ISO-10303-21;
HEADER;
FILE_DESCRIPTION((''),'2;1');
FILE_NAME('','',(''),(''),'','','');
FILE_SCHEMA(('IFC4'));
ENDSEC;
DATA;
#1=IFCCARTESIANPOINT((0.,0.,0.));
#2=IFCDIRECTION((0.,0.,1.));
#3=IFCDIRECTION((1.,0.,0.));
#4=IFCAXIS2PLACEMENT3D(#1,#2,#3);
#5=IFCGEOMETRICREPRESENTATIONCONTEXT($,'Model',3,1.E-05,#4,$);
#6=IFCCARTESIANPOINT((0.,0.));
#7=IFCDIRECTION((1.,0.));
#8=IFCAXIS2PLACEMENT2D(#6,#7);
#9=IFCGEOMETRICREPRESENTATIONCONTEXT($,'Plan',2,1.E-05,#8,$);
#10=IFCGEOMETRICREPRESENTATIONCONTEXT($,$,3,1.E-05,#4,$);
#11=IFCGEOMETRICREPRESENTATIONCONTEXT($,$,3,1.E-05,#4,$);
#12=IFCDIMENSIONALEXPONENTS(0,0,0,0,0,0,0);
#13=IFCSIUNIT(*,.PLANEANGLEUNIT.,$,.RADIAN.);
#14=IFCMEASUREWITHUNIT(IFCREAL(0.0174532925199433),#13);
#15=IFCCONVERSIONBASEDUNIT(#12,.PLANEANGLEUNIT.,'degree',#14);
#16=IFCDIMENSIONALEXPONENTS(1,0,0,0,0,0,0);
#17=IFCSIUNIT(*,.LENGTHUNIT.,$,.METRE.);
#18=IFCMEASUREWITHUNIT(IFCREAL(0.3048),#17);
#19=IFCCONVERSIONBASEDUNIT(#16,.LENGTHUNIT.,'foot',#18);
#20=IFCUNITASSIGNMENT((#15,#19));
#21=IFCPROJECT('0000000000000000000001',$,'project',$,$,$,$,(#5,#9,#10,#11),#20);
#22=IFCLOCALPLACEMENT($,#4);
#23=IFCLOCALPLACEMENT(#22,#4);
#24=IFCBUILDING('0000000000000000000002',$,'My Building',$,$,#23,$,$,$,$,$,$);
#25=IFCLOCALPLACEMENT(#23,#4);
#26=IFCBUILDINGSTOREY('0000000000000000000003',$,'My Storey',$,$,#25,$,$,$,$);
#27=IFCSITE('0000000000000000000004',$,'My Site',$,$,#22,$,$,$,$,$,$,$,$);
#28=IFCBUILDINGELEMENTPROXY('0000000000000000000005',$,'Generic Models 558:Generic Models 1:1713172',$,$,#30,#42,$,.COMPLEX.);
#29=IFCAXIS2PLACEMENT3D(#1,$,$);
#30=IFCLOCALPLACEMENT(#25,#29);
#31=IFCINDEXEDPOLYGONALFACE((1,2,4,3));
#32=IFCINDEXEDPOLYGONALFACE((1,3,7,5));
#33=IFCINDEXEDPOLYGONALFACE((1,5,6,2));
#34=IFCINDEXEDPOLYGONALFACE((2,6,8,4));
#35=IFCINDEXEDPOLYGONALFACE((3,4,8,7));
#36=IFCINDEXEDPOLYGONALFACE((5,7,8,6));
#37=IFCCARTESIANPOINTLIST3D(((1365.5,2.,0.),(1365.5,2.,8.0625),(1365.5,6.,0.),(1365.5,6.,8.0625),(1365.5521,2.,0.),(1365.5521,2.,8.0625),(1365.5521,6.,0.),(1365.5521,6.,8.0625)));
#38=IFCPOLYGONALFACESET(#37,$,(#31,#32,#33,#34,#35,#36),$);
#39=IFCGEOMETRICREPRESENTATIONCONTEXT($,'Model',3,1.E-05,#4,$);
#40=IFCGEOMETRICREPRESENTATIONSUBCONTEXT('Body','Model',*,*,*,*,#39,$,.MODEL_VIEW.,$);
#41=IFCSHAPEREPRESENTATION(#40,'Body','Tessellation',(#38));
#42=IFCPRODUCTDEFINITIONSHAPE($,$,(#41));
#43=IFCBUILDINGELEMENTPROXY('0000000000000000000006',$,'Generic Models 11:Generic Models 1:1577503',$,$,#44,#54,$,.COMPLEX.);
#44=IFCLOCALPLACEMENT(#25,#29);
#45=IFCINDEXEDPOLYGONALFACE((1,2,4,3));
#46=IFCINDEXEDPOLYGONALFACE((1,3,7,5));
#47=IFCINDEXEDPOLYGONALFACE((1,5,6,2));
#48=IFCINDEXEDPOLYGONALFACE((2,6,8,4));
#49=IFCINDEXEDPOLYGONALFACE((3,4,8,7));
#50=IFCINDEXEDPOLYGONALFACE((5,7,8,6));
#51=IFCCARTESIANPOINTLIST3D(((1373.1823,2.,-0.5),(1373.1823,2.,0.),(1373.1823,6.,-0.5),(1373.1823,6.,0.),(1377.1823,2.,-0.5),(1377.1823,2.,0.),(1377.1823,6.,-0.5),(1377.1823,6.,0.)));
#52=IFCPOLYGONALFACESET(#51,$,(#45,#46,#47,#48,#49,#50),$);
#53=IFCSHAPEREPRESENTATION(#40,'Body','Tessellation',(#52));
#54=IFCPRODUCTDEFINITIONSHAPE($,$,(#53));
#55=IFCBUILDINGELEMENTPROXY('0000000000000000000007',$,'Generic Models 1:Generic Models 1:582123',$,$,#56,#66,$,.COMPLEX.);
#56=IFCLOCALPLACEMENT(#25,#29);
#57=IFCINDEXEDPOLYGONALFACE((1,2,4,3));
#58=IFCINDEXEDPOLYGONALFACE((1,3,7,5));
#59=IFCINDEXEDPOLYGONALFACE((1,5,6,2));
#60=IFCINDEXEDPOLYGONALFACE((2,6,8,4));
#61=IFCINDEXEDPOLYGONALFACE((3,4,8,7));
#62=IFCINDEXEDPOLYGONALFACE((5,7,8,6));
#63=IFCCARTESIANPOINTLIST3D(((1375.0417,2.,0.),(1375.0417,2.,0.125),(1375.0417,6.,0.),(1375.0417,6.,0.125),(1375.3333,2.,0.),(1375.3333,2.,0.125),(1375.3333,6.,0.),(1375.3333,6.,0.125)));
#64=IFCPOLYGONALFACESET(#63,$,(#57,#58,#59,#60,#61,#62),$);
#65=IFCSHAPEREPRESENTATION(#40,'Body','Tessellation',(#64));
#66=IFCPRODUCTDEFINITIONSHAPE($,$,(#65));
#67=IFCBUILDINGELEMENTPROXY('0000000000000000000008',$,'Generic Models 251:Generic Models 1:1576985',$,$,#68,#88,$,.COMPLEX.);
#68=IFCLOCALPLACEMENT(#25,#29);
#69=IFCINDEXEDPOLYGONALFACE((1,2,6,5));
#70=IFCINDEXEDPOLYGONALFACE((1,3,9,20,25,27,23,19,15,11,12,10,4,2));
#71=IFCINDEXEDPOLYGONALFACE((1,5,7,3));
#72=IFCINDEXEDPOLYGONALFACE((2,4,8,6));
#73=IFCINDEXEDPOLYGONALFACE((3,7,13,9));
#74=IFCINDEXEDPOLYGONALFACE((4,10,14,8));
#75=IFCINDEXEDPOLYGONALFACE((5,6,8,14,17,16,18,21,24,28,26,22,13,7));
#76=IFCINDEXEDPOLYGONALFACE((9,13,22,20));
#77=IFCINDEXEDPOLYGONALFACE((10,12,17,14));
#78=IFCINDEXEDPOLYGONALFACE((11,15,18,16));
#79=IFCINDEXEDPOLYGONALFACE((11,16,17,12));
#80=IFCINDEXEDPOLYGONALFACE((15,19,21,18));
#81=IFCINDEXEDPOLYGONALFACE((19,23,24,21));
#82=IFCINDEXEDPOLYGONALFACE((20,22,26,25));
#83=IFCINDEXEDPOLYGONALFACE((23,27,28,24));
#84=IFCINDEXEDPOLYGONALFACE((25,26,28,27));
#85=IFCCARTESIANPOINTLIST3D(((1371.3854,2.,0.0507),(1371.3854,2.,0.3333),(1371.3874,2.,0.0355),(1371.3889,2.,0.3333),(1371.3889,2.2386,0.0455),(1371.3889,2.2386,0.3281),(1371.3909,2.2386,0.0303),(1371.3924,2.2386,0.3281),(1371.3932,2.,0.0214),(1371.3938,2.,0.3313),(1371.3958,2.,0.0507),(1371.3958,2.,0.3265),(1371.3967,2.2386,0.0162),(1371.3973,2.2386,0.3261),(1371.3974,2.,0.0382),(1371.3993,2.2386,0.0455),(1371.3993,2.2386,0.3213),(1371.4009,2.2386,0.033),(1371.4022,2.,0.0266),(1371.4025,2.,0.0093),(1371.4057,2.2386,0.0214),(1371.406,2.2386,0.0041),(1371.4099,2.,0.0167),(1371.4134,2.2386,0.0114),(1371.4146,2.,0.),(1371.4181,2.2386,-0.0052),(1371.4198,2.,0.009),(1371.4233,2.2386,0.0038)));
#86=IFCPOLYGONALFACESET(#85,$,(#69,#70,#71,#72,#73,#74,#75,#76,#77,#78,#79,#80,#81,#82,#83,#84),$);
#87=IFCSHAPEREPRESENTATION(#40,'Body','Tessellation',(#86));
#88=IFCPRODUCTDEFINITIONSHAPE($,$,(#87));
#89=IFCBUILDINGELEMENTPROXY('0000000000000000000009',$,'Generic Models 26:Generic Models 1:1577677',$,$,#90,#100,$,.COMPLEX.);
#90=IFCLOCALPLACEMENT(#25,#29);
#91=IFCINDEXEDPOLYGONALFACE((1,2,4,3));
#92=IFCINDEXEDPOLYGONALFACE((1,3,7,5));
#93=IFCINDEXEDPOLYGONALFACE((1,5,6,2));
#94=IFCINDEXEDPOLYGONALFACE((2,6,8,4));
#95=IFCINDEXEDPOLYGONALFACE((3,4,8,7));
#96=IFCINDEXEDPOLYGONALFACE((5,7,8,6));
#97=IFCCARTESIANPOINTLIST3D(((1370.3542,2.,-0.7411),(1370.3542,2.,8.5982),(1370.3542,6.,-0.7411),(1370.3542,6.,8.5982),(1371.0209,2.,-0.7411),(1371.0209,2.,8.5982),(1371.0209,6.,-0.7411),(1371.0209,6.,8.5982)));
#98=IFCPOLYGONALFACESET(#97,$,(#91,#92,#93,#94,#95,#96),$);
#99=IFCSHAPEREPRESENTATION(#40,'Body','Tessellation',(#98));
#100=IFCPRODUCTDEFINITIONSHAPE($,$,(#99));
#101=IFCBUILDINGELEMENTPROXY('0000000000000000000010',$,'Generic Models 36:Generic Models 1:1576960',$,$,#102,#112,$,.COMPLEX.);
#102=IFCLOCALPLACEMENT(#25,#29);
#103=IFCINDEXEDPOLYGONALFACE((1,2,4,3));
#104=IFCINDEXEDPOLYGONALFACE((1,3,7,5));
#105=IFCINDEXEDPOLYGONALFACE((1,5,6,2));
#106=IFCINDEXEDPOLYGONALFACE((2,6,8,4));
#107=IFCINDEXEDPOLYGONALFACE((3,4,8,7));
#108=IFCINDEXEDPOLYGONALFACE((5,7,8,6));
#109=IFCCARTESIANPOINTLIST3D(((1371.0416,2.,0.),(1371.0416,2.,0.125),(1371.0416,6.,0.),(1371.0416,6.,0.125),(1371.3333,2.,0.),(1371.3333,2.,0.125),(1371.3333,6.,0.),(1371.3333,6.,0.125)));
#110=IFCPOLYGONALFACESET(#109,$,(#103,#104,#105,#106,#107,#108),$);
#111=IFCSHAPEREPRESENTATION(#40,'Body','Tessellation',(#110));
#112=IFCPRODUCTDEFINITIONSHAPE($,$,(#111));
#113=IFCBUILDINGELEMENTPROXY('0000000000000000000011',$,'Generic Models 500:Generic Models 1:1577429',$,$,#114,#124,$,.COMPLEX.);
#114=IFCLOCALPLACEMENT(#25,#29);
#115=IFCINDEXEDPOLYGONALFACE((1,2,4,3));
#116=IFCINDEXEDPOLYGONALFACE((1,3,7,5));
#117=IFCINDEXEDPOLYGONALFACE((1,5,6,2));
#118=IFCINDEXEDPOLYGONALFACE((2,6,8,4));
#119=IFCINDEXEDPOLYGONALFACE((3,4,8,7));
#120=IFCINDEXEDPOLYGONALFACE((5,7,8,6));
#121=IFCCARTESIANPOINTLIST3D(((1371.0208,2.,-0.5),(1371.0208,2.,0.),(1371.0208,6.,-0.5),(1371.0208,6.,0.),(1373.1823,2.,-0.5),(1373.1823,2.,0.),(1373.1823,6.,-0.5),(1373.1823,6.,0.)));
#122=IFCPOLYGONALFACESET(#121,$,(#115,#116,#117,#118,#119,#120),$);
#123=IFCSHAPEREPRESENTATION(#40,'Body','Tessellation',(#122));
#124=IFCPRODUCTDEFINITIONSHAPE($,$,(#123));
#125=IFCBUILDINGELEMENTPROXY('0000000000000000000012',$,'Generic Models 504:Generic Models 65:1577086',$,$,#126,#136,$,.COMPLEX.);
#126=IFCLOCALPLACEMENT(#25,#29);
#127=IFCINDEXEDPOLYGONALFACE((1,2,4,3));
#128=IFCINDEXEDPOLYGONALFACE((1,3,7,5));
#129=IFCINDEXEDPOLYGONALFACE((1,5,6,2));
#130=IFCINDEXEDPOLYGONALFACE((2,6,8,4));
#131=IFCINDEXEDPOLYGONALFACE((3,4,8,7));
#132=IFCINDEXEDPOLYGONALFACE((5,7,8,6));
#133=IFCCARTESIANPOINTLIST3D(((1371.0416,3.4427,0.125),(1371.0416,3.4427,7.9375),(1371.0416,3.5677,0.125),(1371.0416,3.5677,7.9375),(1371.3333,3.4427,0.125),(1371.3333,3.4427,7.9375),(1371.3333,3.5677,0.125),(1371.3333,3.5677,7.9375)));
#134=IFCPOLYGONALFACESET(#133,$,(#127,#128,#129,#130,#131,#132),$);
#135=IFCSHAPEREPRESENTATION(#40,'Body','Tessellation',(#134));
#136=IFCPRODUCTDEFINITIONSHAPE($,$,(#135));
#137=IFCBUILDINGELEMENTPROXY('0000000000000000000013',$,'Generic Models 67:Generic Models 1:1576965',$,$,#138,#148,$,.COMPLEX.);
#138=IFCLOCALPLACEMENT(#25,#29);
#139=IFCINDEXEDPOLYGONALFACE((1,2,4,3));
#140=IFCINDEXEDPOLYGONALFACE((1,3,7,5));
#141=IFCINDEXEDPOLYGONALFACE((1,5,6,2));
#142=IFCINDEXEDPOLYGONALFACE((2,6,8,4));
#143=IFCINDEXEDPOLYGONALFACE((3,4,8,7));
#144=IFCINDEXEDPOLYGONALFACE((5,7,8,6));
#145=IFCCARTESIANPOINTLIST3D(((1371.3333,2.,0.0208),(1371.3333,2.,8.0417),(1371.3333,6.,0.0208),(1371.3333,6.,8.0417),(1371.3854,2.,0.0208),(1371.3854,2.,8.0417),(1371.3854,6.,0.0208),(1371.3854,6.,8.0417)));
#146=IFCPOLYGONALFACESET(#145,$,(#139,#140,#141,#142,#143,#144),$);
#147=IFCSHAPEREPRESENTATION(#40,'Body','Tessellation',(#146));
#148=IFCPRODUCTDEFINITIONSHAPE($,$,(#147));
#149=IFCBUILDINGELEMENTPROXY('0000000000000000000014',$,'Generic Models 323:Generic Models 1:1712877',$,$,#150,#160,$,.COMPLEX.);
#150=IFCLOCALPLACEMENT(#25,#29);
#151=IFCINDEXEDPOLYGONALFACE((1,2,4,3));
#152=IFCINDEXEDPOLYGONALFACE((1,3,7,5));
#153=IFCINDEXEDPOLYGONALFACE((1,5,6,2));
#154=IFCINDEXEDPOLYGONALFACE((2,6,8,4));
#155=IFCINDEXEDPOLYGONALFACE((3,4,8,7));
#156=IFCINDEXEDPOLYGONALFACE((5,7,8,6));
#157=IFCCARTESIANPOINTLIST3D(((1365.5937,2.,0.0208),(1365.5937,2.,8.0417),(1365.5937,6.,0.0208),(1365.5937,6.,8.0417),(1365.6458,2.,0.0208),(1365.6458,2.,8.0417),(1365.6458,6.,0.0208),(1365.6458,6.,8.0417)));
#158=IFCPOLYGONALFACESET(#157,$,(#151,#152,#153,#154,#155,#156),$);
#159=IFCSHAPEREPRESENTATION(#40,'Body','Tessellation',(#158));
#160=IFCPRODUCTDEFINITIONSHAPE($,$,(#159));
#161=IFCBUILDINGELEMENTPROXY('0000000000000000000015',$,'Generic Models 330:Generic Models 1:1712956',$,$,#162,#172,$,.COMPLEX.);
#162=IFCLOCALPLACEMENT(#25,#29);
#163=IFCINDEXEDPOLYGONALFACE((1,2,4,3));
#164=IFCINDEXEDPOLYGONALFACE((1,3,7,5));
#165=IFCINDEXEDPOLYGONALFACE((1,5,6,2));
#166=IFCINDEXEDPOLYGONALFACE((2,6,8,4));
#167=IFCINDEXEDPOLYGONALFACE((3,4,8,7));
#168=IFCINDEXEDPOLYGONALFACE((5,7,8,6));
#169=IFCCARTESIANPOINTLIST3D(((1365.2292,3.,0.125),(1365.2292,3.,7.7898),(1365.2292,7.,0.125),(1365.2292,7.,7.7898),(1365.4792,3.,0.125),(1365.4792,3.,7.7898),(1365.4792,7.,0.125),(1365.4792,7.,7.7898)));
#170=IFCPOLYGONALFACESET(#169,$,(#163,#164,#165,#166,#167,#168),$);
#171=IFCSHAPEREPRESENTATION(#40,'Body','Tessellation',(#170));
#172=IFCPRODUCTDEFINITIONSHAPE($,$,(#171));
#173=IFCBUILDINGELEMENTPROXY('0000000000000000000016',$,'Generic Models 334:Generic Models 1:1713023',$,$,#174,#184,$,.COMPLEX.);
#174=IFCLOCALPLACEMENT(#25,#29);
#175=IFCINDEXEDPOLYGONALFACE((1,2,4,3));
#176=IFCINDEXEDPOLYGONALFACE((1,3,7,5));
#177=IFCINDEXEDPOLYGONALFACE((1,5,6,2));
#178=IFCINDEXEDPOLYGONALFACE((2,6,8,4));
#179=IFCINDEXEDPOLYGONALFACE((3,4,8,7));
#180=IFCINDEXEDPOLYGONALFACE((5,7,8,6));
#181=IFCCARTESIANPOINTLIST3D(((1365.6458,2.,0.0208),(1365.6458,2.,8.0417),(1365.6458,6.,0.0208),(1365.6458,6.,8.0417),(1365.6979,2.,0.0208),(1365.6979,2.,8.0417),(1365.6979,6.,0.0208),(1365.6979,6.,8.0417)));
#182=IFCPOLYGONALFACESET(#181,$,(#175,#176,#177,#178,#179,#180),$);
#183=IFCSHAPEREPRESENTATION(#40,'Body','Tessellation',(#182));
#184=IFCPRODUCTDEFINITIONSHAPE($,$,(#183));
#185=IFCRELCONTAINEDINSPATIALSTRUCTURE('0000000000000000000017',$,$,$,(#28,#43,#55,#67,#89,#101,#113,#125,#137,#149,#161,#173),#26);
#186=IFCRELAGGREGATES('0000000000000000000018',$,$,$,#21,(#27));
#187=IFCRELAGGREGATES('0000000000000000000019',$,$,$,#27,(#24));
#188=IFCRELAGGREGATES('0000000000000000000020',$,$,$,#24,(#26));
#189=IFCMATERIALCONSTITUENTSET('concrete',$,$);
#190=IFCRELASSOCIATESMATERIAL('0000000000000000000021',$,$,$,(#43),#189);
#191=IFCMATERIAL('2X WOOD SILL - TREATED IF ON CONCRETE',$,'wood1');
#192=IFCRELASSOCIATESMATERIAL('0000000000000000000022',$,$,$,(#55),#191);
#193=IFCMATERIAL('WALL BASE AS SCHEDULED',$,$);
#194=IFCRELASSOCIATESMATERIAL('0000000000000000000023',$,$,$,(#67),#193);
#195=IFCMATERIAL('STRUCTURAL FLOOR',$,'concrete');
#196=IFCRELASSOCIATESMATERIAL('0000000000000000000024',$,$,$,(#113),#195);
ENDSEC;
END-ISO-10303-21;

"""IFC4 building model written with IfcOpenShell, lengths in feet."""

from ifc_helpers import new_model, entity, si_unit, converted_unit, frame, origin_with_axes, origin_2d_with_axis, place, context, subcontext, project, spatial, polyline, outline, extrude, material, constituent_set, element, save


model = new_model("IFC4")

# Units and contexts
model_context_1 = context("Model", 3, precision=1e-05, world=origin_with_axes())
plan_context = context("Plan", 2, precision=1e-05, world=origin_2d_with_axis())
model_context_2 = context("Model", 3, precision=1e-05, world=origin_with_axes())
context_of_model_1 = context(None, 3, precision=1e-05, world=origin_with_axes())
context_of_model_2 = context(None, 3, precision=1e-05, world=origin_with_axes())
body_context = subcontext(model_context_2, "Body", "Model", "MODEL_VIEW")
ifc_project = project(units=[converted_unit("PLANEANGLEUNIT", "degree", entity("IfcReal", 0.0174532925199433), si_unit("PLANEANGLEUNIT", "RADIAN"), dimensions=[0, 0, 0, 0, 0, 0, 0]), converted_unit("LENGTHUNIT", "foot", entity("IfcReal", 0.3048), si_unit("LENGTHUNIT", "METRE"), dimensions=[1, 0, 0, 0, 0, 0, 0])], contexts=[model_context_1, plan_context, context_of_model_1, context_of_model_2])

# Site, building, storey
site_placement = place(None, origin_with_axes())
site = spatial("IfcSite", under=ifc_project, at=site_placement, Name="My Site")
building_placement = place(site_placement, origin_with_axes())
building = spatial("IfcBuilding", under=site, at=building_placement, Name="My Building")
storey_placement = place(building_placement, origin_with_axes())
storey = spatial("IfcBuildingStorey", under=building, at=storey_placement, Name="My Storey")

# Building element proxies
proxy_1_placement = place(storey_placement, frame((1365.5, 6.0, 0.0), z_axis=(0.0, -1.0, 0.0), x_axis=(0.0, 0.0, 1.0)))
element("IfcBuildingElementProxy", 1, at=proxy_1_placement, inside=storey, Name="Generic Models 558:Generic Models 1:1713172", PredefinedType="COMPLEX", context=body_context, shape_type="SweptSolid", body=[
    extrude(outline(polyline([(-4.0312, -0.026), (4.0312, -0.026), (4.0312, 0.026), (-4.0312, 0.026), (-4.0312, -0.026)])), frame((4.0312, -0.026, 0.0), z_axis=(0.0, 0.0, -1.0), x_axis=(1.0, 0.0, 0.0)), (0.0, 0.0, -1.0), 4.0),
])
ifc_constituent_set = constituent_set(Name="concrete")
proxy_2_placement = place(storey_placement, frame((1373.1823, 6.0, -0.5), z_axis=(0.0, -1.0, 0.0), x_axis=(0.0, 0.0, -1.0)))
element("IfcBuildingElementProxy", 2, at=proxy_2_placement, inside=storey, material=ifc_constituent_set, Name="Generic Models 11:Generic Models 1:1577503", PredefinedType="COMPLEX", context=body_context, shape_type="SweptSolid", body=[
    extrude(outline(polyline([(-0.25, -2.0), (0.25, -2.0), (0.25, 2.0), (-0.25, 2.0), (-0.25, -2.0)])), frame((-0.25, 2.0, 0.0), z_axis=(0.0, 0.0, -1.0), x_axis=(-1.0, 0.0, 0.0)), (0.0, 0.0, -1.0), 4.0),
])
ifc_material_1 = material(Name="2X WOOD SILL - TREATED IF ON CONCRETE", Category="wood1")
proxy_3_placement = place(storey_placement, frame((1375.0417, 6.0, 0.0), z_axis=(0.0, -1.0, 0.0), x_axis=(0.0, 0.0, -1.0)))
element("IfcBuildingElementProxy", 3, at=proxy_3_placement, inside=storey, material=ifc_material_1, Name="Generic Models 1:Generic Models 1:582123", PredefinedType="COMPLEX", context=body_context, shape_type="SweptSolid", body=[
    extrude(outline(polyline([(-0.0625, -0.1458), (0.0625, -0.1458), (0.0625, 0.1458), (-0.0625, 0.1458), (-0.0625, -0.1458)])), frame((-0.0625, 0.1458, 0.0), z_axis=(0.0, 0.0, -1.0), x_axis=(1.0, 0.0, 0.0)), (0.0, 0.0, -1.0), 4.0),
])
ifc_material_2 = material(Name="WALL BASE AS SCHEDULED")
proxy_4_placement = place(storey_placement, frame((1371.3854, 6.0, 0.0), z_axis=(0.0, -1.0, 0.0), x_axis=(0.0, 0.0, -1.0)))
element("IfcBuildingElementProxy", 4, at=proxy_4_placement, inside=storey, material=ifc_material_2, Name="Generic Models 251:Generic Models 1:1576985", PredefinedType="COMPLEX", context=body_context, shape_type="SweptSolid", body=[
    extrude(outline(polyline([(0.0971, 0.0), (0.1059, -0.009), (0.1142, -0.0027), (0.1035, 0.0082), (0.0904, 0.016), (0.0756, 0.02), (0.0603, 0.0202), (-0.2202, -0.0144), (-0.2197, -0.0179), (-0.2172, -0.0225), (-0.2121, -0.0239), (0.0616, 0.0098), (0.0742, 0.0097), (0.0863, 0.0064), (0.0971, 0.0)])), frame((-0.1078, 0.0161, 3.7614), z_axis=(-0.000001, 0.0, -1.0), x_axis=(0.992503, 0.122219, -0.000004)), (-0.023549, 0.011857, -0.999652), 0.2387),
])
proxy_5_placement = place(storey_placement, frame((1370.3542, 6.0, -0.7411), z_axis=(0.0, -1.0, 0.0), x_axis=(0.0, 0.0, -1.0)))
element("IfcBuildingElementProxy", 5, at=proxy_5_placement, inside=storey, Name="Generic Models 26:Generic Models 1:1577677", PredefinedType="COMPLEX", context=body_context, shape_type="SweptSolid", body=[
    extrude(outline(polyline([(-0.3333, -4.6697), (0.3333, -4.6697), (0.3333, 4.6697), (-0.3333, 4.6697), (-0.3333, -4.6697)])), frame((-4.6697, 0.3333, 0.0), z_axis=(0.0, 0.0, -1.0), x_axis=(0.0, -1.0, 0.0)), (0.0, 0.0, -1.0), 4.0),
])
proxy_6_placement = place(storey_placement, frame((1371.0416, 6.0, 0.0), z_axis=(0.0, -1.0, 0.0), x_axis=(0.0, 0.0, -1.0)))
element("IfcBuildingElementProxy", 6, at=proxy_6_placement, inside=storey, Name="Generic Models 36:Generic Models 1:1576960", PredefinedType="COMPLEX", context=body_context, shape_type="SweptSolid", body=[
    extrude(outline(polyline([(-0.0625, -0.1458), (0.0625, -0.1458), (0.0625, 0.1458), (-0.0625, 0.1458), (-0.0625, -0.1458)])), frame((-0.0625, 0.1458, 0.0), z_axis=(0.0, 0.0, -1.0), x_axis=(1.0, 0.0, 0.0)), (0.0, 0.0, -1.0), 4.0),
])
ifc_material_3 = material(Name="STRUCTURAL FLOOR", Category="concrete")
proxy_7_placement = place(storey_placement, frame((1371.0208, 6.0, -0.5), z_axis=(0.0, -1.0, 0.0), x_axis=(0.0, 0.0, -1.0)))
element("IfcBuildingElementProxy", 7, at=proxy_7_placement, inside=storey, material=ifc_material_3, Name="Generic Models 500:Generic Models 1:1577429", PredefinedType="COMPLEX", context=body_context, shape_type="SweptSolid", body=[
    extrude(outline(polyline([(-0.25, -1.0807), (0.25, -1.0807), (0.25, 1.0807), (-0.25, 1.0807), (-0.25, -1.0807)])), frame((-0.25, 1.0807, 0.0), z_axis=(0.0, 0.0, -1.0), x_axis=(1.0, 0.0, 0.0)), (0.0, 0.0, -1.0), 4.0),
])
proxy_8_placement = place(storey_placement, frame((1371.0416, 3.4427, 0.125), z_axis=(1.0, 0.0, 0.0), x_axis=(0.0, 0.0, -1.0)))
element("IfcBuildingElementProxy", 8, at=proxy_8_placement, inside=storey, Name="Generic Models 504:Generic Models 65:1577086", PredefinedType="COMPLEX", context=body_context, shape_type="SweptSolid", body=[
    extrude(outline(polyline([(-3.9062, -0.0625), (3.9062, -0.0625), (3.9062, 0.0625), (-3.9062, 0.0625), (-3.9062, -0.0625)])), frame((-3.9062, 0.0625, 0.0), z_axis=(0.0, 0.0, -1.0), x_axis=(1.0, 0.0, 0.0)), (0.0, 0.0, -1.0), 0.2917),
])
proxy_9_placement = place(storey_placement, frame((1371.3333, 6.0, 0.0208), z_axis=(0.0, -1.0, 0.0), x_axis=(0.0, 0.0, -1.0)))
element("IfcBuildingElementProxy", 9, at=proxy_9_placement, inside=storey, Name="Generic Models 67:Generic Models 1:1576965", PredefinedType="COMPLEX", context=body_context, shape_type="SweptSolid", body=[
    extrude(outline(polyline([(-0.026, -4.0104), (0.026, -4.0104), (0.026, 4.0104), (-0.026, 4.0104), (-0.026, -4.0104)])), frame((-4.0104, 0.026, 0.0), z_axis=(0.0, 0.0, -1.0), x_axis=(0.0, 1.0, 0.0)), (0.0, 0.0, -1.0), 4.0),
])
proxy_10_placement = place(storey_placement, frame((1365.5937, 6.0, 0.0208), z_axis=(0.0, -1.0, 0.0), x_axis=(0.0, 0.0, 1.0)))
element("IfcBuildingElementProxy", 10, at=proxy_10_placement, inside=storey, Name="Generic Models 323:Generic Models 1:1712877", PredefinedType="COMPLEX", context=body_context, shape_type="SweptSolid", body=[
    extrude(outline(polyline([(-4.0104, -0.026), (4.0104, -0.026), (4.0104, 0.026), (-4.0104, 0.026), (-4.0104, -0.026)])), frame((4.0104, -0.026, 0.0), z_axis=(0.0, 0.0, -1.0), x_axis=(1.0, 0.0, 0.0)), (0.0, 0.0, -1.0), 4.0),
])
proxy_11_placement = place(storey_placement, frame((1365.2292, 3.0, 0.125), z_axis=(0.0, 0.0, 1.0), x_axis=(0.0, 1.0, 0.0)))
element("IfcBuildingElementProxy", 11, at=proxy_11_placement, inside=storey, Name="Generic Models 330:Generic Models 1:1712956", PredefinedType="COMPLEX", context=body_context, shape_type="SweptSolid", body=[
    extrude(outline(polyline([(-2.0, -0.125), (2.0, -0.125), (2.0, 0.125), (-2.0, 0.125), (-2.0, -0.125)])), frame((2.0, -0.125, 0.0), z_axis=(0.0, 0.0, -1.0), x_axis=(-1.0, 0.0, 0.0)), (0.0, 0.0, -1.0), 7.6648),
])
proxy_12_placement = place(storey_placement, frame((1365.6458, 6.0, 0.0208), z_axis=(0.0, -1.0, 0.0), x_axis=(0.0, 0.0, 1.0)))
element("IfcBuildingElementProxy", 12, at=proxy_12_placement, inside=storey, Name="Generic Models 334:Generic Models 1:1713023", PredefinedType="COMPLEX", context=body_context, shape_type="SweptSolid", body=[
    extrude(outline(polyline([(-4.0104, -0.026), (4.0104, -0.026), (4.0104, 0.026), (-4.0104, 0.026), (-4.0104, -0.026)])), frame((4.0104, -0.026, 0.0), z_axis=(0.0, 0.0, -1.0), x_axis=(1.0, 0.0, 0.0)), (0.0, 0.0, -1.0), 4.0),
])

save(model, "model.ifc")
